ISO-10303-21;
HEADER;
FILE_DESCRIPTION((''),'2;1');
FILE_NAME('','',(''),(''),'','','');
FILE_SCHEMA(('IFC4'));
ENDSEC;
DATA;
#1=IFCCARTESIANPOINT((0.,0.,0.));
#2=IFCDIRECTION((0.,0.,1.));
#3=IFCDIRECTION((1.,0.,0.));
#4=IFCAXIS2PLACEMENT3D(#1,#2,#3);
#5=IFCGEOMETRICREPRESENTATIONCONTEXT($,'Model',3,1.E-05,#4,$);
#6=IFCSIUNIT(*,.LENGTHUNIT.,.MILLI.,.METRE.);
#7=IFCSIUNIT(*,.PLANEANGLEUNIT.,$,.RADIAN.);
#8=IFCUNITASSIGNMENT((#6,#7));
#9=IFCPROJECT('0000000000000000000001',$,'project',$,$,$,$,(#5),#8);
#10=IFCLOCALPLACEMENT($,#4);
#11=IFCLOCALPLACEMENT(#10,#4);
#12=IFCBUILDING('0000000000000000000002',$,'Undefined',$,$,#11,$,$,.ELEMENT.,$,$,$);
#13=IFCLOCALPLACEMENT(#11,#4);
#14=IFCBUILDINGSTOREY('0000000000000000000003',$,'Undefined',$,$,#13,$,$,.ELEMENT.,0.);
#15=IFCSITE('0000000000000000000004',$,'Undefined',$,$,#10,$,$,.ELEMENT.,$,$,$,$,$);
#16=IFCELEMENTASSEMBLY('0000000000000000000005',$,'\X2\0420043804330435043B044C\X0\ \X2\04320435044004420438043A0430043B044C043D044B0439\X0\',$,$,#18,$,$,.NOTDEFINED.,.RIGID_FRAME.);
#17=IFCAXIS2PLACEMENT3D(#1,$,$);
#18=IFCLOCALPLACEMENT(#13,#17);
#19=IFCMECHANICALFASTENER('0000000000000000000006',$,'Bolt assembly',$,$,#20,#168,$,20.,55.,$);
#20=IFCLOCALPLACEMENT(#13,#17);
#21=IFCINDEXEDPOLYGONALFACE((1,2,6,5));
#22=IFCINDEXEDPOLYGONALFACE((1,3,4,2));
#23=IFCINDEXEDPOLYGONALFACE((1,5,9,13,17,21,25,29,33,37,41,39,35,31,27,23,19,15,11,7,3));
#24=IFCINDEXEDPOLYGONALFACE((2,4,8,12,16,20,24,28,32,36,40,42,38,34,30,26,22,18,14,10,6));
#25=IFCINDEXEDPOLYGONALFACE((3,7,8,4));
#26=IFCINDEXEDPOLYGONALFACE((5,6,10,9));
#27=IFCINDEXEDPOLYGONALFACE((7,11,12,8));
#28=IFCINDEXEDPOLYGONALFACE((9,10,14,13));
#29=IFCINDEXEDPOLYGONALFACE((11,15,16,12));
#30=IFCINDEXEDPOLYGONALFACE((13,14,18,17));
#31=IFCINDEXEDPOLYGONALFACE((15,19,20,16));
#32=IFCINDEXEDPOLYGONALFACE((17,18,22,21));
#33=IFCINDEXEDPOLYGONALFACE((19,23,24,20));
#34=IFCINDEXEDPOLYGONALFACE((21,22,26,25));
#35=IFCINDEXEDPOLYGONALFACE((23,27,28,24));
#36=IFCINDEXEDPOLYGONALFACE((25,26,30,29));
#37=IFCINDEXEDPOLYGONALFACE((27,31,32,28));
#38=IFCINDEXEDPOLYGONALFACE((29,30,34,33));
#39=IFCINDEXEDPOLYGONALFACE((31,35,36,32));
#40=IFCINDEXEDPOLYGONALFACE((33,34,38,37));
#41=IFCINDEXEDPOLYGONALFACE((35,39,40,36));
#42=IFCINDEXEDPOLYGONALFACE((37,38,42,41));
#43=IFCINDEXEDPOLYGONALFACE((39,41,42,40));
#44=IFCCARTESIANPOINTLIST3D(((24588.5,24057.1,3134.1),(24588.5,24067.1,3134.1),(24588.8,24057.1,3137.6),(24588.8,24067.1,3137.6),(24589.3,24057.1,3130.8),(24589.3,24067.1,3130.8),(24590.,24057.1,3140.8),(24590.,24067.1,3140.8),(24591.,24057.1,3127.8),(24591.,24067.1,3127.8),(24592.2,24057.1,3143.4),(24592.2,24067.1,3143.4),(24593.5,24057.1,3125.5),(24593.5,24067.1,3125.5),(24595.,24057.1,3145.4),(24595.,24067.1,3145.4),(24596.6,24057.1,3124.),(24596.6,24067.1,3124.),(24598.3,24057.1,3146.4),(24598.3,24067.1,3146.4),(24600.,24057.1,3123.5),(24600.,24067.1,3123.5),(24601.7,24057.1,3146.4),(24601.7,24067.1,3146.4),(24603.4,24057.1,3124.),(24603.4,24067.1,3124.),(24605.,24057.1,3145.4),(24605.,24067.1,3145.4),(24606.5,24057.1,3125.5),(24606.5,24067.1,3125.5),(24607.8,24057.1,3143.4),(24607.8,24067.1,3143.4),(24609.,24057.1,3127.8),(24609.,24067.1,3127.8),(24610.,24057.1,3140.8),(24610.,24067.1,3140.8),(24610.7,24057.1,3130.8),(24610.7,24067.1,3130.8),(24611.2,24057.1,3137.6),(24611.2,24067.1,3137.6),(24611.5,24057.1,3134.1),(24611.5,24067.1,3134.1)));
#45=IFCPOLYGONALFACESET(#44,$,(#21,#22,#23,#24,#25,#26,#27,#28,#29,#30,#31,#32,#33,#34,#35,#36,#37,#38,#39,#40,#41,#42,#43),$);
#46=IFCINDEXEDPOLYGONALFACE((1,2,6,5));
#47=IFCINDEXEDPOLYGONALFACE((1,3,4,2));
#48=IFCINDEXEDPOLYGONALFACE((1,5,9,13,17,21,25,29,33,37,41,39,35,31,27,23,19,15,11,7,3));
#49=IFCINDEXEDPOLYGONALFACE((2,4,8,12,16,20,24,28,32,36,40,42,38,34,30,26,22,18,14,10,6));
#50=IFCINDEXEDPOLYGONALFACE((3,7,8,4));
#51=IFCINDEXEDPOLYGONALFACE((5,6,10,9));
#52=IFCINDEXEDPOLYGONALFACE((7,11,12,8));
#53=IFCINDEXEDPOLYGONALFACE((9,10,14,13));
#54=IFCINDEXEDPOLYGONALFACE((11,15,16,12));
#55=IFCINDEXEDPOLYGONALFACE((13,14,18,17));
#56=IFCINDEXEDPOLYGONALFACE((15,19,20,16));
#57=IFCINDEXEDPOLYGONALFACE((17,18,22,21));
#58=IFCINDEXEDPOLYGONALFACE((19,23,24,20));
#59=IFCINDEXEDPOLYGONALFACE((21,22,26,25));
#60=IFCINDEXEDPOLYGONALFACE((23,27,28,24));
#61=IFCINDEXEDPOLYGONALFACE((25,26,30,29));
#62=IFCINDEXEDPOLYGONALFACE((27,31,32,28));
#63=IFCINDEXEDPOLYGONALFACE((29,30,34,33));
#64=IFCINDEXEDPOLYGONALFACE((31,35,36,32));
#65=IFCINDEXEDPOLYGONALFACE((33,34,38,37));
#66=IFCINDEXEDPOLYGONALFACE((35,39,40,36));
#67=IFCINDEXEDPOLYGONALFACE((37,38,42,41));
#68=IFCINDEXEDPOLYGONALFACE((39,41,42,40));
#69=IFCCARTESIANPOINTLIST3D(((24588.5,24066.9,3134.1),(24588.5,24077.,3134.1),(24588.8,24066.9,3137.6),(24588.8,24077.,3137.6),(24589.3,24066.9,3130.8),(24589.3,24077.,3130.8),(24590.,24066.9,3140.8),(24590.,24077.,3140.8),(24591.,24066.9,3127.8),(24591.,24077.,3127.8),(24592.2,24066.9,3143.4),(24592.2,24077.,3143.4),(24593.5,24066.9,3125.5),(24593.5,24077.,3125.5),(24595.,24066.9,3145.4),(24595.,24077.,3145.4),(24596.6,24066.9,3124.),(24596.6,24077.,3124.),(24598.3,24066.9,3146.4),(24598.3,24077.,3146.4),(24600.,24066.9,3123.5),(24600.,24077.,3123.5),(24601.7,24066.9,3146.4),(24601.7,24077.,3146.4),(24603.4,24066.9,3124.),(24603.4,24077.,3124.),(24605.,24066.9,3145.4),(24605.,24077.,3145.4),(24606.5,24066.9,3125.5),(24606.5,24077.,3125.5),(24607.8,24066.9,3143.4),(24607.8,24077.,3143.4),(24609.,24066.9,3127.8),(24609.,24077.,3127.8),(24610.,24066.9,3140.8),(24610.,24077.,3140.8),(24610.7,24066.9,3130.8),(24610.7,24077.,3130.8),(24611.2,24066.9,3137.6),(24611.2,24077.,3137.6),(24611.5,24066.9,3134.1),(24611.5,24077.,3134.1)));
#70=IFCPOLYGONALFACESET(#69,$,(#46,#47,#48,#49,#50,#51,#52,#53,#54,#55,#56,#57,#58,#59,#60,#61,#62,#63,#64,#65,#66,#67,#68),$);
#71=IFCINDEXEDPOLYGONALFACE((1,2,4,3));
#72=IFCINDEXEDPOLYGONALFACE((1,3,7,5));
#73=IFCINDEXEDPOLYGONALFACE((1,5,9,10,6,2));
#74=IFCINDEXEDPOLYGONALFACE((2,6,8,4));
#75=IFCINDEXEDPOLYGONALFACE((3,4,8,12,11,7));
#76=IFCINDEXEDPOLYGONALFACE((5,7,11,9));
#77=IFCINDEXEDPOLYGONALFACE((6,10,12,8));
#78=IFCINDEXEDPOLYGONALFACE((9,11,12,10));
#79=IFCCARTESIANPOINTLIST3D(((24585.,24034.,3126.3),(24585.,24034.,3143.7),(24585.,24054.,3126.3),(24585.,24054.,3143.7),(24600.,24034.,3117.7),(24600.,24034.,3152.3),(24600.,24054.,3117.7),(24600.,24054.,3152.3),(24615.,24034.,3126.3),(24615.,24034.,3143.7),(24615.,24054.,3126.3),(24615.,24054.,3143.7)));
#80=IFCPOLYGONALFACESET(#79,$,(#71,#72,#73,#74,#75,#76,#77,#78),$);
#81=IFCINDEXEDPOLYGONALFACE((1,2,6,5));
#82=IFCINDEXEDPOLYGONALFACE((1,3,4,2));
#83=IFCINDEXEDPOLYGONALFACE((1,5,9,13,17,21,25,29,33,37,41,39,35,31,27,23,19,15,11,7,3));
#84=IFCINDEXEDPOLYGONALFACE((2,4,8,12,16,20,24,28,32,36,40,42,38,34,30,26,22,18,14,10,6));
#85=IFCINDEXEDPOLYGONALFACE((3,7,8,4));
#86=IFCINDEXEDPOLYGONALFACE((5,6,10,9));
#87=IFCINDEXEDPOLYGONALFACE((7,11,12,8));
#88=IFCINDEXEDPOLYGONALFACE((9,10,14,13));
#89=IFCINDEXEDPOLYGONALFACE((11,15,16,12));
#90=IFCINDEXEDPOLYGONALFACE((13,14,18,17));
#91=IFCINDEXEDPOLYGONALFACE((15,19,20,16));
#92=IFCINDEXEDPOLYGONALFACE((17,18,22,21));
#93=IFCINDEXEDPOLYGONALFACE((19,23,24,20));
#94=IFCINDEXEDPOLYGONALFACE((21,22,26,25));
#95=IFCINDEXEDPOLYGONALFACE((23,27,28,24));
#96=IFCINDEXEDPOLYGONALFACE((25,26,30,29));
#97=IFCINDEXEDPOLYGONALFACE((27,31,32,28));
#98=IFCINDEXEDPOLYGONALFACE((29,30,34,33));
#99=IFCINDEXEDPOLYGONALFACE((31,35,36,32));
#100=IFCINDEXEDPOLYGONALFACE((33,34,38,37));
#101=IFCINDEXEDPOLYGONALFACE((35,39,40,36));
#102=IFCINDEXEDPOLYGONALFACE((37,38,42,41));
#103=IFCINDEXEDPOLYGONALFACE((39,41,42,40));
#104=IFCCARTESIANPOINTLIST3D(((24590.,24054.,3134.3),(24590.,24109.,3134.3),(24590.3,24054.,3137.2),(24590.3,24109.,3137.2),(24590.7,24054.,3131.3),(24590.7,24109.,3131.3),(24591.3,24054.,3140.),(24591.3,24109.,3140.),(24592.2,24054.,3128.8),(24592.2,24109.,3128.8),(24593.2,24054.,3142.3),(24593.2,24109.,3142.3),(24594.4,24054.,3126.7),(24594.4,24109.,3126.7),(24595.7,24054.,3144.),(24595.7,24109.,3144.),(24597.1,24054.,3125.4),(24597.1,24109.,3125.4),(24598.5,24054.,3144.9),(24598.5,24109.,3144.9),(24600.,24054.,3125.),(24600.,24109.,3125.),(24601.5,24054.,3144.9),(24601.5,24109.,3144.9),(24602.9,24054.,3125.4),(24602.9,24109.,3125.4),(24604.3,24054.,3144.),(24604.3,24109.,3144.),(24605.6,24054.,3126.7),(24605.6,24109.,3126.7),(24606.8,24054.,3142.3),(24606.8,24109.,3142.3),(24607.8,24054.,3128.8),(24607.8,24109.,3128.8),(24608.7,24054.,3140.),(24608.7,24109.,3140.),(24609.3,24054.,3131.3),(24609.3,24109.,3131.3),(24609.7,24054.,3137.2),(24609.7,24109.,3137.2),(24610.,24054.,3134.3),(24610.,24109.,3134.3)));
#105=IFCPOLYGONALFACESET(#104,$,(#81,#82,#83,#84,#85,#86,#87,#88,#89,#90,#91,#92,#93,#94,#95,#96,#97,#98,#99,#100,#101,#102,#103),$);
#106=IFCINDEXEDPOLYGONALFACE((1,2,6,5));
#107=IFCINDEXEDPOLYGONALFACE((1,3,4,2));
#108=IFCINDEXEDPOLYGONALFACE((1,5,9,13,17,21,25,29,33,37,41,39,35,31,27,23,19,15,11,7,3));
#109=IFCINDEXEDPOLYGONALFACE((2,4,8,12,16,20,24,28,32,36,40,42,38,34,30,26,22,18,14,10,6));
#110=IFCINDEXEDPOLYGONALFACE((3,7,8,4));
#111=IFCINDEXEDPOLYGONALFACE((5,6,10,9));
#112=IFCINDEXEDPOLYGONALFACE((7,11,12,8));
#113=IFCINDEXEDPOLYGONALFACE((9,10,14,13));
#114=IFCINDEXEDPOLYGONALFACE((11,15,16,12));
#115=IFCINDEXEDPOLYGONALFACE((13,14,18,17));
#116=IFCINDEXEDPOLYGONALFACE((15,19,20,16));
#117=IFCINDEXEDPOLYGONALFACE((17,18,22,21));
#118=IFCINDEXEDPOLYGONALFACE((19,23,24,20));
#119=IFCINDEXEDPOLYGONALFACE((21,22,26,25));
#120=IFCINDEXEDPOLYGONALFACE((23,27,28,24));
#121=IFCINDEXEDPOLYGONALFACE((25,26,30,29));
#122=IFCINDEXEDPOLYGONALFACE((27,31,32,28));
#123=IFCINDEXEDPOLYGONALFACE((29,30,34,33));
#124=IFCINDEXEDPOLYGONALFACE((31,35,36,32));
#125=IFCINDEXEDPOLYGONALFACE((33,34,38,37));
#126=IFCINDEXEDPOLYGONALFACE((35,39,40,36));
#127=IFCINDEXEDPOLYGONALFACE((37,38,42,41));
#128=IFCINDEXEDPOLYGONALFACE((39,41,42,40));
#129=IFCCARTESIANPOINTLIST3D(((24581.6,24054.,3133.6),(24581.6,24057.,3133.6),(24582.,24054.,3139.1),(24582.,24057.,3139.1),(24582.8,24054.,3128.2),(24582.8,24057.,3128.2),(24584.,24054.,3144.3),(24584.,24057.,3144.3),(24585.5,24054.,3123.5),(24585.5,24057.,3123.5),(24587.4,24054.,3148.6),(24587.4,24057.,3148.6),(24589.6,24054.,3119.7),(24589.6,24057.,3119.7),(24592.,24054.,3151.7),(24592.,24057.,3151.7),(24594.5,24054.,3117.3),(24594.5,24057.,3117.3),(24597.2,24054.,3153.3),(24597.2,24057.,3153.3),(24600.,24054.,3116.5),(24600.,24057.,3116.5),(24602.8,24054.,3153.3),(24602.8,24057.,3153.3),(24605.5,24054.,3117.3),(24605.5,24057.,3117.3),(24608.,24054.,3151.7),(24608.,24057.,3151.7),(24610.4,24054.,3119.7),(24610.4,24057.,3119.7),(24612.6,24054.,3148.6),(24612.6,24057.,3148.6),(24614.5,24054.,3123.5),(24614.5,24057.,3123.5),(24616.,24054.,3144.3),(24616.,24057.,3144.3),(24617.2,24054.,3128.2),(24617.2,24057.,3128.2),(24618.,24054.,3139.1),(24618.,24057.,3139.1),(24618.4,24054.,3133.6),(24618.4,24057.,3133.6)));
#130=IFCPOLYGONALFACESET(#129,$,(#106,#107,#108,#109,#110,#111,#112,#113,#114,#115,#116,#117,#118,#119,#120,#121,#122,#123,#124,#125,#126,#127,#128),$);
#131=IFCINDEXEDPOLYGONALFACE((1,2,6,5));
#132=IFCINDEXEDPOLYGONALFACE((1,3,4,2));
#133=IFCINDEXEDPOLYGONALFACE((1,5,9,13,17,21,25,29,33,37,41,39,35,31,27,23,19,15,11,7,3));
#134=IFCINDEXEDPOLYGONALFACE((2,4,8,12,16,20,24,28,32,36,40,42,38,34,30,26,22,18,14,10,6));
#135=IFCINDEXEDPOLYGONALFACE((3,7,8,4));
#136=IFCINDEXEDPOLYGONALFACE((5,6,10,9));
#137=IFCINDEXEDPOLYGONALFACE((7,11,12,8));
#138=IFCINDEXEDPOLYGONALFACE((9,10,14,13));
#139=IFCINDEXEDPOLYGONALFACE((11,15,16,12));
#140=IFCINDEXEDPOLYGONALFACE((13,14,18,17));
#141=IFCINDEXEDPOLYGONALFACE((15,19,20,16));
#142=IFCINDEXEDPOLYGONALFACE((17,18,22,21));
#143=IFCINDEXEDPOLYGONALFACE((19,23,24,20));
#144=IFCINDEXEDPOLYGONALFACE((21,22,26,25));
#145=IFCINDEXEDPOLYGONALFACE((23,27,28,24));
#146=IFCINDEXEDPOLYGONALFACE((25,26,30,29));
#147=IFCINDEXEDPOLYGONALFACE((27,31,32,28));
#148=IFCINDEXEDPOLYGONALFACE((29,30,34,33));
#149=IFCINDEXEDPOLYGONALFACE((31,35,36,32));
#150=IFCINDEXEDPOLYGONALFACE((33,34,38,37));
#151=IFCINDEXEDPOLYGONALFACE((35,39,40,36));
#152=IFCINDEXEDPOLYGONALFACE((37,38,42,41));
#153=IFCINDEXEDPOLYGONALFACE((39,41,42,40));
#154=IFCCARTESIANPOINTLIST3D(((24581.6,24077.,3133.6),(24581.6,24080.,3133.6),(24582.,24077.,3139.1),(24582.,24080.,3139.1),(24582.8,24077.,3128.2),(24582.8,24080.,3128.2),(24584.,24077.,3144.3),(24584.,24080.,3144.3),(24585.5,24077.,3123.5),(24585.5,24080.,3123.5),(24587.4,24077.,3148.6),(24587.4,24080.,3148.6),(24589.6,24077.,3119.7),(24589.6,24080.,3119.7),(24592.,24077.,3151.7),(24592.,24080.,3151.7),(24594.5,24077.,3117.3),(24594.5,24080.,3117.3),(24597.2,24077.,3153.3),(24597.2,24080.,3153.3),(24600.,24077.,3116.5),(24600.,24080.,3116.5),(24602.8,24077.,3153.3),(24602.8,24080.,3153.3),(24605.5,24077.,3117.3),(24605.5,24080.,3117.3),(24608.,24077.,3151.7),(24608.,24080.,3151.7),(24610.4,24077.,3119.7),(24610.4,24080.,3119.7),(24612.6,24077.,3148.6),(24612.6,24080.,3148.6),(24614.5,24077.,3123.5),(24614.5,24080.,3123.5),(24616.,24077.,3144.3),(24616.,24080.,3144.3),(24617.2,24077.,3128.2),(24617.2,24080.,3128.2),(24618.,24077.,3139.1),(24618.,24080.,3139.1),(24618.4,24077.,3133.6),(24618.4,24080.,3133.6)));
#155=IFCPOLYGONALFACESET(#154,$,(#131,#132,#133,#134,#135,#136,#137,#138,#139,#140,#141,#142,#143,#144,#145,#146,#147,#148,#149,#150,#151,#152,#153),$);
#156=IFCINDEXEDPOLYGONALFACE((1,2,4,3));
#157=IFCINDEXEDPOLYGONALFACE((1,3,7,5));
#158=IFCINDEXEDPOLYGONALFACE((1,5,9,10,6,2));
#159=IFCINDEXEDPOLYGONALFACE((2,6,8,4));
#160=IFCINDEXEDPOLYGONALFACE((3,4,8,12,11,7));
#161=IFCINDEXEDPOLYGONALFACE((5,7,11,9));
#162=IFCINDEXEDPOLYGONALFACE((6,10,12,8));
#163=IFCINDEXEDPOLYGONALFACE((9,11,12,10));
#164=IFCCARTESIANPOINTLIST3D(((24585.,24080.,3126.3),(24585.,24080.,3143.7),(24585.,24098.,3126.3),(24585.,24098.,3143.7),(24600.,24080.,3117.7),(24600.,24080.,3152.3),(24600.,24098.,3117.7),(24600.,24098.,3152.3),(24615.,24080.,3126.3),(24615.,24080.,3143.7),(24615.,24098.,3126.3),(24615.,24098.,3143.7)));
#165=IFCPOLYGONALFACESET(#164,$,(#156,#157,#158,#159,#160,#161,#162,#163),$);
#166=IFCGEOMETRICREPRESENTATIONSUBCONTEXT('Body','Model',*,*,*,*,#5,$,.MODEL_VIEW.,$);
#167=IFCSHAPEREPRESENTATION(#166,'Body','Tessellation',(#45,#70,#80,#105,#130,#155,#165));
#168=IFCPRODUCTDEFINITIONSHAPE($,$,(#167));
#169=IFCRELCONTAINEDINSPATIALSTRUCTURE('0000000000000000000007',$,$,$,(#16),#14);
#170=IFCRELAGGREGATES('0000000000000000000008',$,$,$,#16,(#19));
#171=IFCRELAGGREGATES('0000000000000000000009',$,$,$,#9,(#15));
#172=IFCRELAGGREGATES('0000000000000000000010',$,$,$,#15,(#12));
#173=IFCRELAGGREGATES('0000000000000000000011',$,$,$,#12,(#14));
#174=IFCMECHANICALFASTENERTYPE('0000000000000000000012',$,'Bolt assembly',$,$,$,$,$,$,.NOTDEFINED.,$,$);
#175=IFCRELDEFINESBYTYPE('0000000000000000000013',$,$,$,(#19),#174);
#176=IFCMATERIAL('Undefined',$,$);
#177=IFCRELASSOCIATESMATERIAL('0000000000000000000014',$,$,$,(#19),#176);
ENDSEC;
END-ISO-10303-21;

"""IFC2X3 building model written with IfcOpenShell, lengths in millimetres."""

from ifc_helpers import new_model, si_unit, frame, origin_with_axes, origin_2d_with_axis, place, context, subcontext, project, spatial, polyline, circle, outline, extrude, source, transform, mapped, material, type_object, element, aggregate, save


model = new_model("IFC2X3")

# Units and contexts
model_context = context("Model", 3, precision=1e-05, world=origin_with_axes())
body_context = subcontext(model_context, "Body", "Model", "MODEL_VIEW")
ifc_project = project(units=[si_unit("LENGTHUNIT", "METRE", prefix="MILLI"), si_unit("PLANEANGLEUNIT", "RADIAN")], contexts=[model_context])

# Site, building, storey
site_placement = place(None, origin_with_axes())
site = spatial("IfcSite", under=ifc_project, at=site_placement, Name="Undefined", CompositionType="ELEMENT")
building_placement = place(site_placement, origin_with_axes())
building = spatial("IfcBuilding", under=site, at=building_placement, Name="Undefined", CompositionType="ELEMENT")
storey_placement = place(building_placement, origin_with_axes())
storey = spatial("IfcBuildingStorey", under=building, at=storey_placement, Name="Undefined", CompositionType="ELEMENT", Elevation=0.0)

# Element assembly
assembly_1_placement = place(storey_placement, origin_with_axes())
assembly_1 = element("IfcElementAssembly", 1, at=assembly_1_placement, inside=storey, Name="Ригель вертикальный", AssemblyPlace="NOTDEFINED", PredefinedType="RIGID_FRAME")

# Mechanical fastener
ifc_material_1 = material(Name="Undefined")
mechanical_fastener_type = type_object("IfcMechanicalFastenerType", Name="Bolt assembly")
shared_shape = source(origin_with_axes(), body_context, "Body", "SweptSolid", [
    extrude(circle(Radius=11.5, at=origin_2d_with_axis()), frame((0.0, 0.1, 0.0), z_axis=(0.0, 1.0, 0.0), x_axis=(1.0, 0.0, 0.0)), (0.0, 0.0, 1.0), 10.0),
    extrude(circle(Radius=11.5, at=origin_2d_with_axis()), frame((0.0, 9.9, 0.0), z_axis=(0.0, 1.0, 0.0), x_axis=(1.0, 0.0, 0.0)), (0.0, 0.0, 1.0), 10.1),
    extrude(outline(polyline([(17.3, 0.0), (8.7, 15.0), (-8.7, 15.0), (-17.3, 0.0), (-8.7, -15.0), (8.7, -15.0), (17.3, 0.0)])), frame((0.0, -23.0, 0.0), z_axis=(0.0, 1.0, 0.0), x_axis=(1.0, 0.0, 0.0)), (0.0, 0.0, 1.0), 20.0),
    extrude(circle(Radius=10.0, at=origin_2d_with_axis()), frame((0.0, -3.0, 0.0), z_axis=(0.0, 1.0, 0.0), x_axis=(1.0, 0.0, 0.0)), (0.0, 0.0, 1.0), 55.0),
    extrude(circle(Radius=18.5, at=origin_2d_with_axis()), frame((0.0, -3.0, 0.0), z_axis=(0.0, 1.0, 0.0), x_axis=(1.0, 0.0, 0.0)), (0.0, 0.0, 1.0), 3.0),
    extrude(circle(Radius=18.5, at=origin_2d_with_axis()), frame((0.0, 20.0, 0.0), z_axis=(0.0, 1.0, 0.0), x_axis=(1.0, 0.0, 0.0)), (0.0, 0.0, 1.0), 3.0),
    extrude(outline(polyline([(17.3, 0.0), (8.7, 15.0), (-8.7, 15.0), (-17.3, 0.0), (-8.7, -15.0), (8.7, -15.0), (17.3, 0.0)])), frame((0.0, 23.0, 0.0), z_axis=(0.0, 1.0, 0.0), x_axis=(1.0, 0.0, 0.0)), (0.0, 0.0, 1.0), 18.0),
])
mechanical_fastener_1_placement = place(assembly_1_placement, frame((24600.0, 24057.0, 3135.0), z_axis=(1.0, 0.0, 0.0), x_axis=(0.0, 0.0, -1.0)))
mechanical_fastener_1 = element("IfcMechanicalFastener", 2, at=mechanical_fastener_1_placement, type_object=mechanical_fastener_type, material=ifc_material_1, Name="Bolt assembly", NominalDiameter=20.0, NominalLength=55.0, context=body_context, shape_type="MappedRepresentation", body=[
    mapped(shared_shape, transform((0.0, 0.0, 0.0))),
])
aggregate(assembly_1, [mechanical_fastener_1])

save(model, "model.ifc")
